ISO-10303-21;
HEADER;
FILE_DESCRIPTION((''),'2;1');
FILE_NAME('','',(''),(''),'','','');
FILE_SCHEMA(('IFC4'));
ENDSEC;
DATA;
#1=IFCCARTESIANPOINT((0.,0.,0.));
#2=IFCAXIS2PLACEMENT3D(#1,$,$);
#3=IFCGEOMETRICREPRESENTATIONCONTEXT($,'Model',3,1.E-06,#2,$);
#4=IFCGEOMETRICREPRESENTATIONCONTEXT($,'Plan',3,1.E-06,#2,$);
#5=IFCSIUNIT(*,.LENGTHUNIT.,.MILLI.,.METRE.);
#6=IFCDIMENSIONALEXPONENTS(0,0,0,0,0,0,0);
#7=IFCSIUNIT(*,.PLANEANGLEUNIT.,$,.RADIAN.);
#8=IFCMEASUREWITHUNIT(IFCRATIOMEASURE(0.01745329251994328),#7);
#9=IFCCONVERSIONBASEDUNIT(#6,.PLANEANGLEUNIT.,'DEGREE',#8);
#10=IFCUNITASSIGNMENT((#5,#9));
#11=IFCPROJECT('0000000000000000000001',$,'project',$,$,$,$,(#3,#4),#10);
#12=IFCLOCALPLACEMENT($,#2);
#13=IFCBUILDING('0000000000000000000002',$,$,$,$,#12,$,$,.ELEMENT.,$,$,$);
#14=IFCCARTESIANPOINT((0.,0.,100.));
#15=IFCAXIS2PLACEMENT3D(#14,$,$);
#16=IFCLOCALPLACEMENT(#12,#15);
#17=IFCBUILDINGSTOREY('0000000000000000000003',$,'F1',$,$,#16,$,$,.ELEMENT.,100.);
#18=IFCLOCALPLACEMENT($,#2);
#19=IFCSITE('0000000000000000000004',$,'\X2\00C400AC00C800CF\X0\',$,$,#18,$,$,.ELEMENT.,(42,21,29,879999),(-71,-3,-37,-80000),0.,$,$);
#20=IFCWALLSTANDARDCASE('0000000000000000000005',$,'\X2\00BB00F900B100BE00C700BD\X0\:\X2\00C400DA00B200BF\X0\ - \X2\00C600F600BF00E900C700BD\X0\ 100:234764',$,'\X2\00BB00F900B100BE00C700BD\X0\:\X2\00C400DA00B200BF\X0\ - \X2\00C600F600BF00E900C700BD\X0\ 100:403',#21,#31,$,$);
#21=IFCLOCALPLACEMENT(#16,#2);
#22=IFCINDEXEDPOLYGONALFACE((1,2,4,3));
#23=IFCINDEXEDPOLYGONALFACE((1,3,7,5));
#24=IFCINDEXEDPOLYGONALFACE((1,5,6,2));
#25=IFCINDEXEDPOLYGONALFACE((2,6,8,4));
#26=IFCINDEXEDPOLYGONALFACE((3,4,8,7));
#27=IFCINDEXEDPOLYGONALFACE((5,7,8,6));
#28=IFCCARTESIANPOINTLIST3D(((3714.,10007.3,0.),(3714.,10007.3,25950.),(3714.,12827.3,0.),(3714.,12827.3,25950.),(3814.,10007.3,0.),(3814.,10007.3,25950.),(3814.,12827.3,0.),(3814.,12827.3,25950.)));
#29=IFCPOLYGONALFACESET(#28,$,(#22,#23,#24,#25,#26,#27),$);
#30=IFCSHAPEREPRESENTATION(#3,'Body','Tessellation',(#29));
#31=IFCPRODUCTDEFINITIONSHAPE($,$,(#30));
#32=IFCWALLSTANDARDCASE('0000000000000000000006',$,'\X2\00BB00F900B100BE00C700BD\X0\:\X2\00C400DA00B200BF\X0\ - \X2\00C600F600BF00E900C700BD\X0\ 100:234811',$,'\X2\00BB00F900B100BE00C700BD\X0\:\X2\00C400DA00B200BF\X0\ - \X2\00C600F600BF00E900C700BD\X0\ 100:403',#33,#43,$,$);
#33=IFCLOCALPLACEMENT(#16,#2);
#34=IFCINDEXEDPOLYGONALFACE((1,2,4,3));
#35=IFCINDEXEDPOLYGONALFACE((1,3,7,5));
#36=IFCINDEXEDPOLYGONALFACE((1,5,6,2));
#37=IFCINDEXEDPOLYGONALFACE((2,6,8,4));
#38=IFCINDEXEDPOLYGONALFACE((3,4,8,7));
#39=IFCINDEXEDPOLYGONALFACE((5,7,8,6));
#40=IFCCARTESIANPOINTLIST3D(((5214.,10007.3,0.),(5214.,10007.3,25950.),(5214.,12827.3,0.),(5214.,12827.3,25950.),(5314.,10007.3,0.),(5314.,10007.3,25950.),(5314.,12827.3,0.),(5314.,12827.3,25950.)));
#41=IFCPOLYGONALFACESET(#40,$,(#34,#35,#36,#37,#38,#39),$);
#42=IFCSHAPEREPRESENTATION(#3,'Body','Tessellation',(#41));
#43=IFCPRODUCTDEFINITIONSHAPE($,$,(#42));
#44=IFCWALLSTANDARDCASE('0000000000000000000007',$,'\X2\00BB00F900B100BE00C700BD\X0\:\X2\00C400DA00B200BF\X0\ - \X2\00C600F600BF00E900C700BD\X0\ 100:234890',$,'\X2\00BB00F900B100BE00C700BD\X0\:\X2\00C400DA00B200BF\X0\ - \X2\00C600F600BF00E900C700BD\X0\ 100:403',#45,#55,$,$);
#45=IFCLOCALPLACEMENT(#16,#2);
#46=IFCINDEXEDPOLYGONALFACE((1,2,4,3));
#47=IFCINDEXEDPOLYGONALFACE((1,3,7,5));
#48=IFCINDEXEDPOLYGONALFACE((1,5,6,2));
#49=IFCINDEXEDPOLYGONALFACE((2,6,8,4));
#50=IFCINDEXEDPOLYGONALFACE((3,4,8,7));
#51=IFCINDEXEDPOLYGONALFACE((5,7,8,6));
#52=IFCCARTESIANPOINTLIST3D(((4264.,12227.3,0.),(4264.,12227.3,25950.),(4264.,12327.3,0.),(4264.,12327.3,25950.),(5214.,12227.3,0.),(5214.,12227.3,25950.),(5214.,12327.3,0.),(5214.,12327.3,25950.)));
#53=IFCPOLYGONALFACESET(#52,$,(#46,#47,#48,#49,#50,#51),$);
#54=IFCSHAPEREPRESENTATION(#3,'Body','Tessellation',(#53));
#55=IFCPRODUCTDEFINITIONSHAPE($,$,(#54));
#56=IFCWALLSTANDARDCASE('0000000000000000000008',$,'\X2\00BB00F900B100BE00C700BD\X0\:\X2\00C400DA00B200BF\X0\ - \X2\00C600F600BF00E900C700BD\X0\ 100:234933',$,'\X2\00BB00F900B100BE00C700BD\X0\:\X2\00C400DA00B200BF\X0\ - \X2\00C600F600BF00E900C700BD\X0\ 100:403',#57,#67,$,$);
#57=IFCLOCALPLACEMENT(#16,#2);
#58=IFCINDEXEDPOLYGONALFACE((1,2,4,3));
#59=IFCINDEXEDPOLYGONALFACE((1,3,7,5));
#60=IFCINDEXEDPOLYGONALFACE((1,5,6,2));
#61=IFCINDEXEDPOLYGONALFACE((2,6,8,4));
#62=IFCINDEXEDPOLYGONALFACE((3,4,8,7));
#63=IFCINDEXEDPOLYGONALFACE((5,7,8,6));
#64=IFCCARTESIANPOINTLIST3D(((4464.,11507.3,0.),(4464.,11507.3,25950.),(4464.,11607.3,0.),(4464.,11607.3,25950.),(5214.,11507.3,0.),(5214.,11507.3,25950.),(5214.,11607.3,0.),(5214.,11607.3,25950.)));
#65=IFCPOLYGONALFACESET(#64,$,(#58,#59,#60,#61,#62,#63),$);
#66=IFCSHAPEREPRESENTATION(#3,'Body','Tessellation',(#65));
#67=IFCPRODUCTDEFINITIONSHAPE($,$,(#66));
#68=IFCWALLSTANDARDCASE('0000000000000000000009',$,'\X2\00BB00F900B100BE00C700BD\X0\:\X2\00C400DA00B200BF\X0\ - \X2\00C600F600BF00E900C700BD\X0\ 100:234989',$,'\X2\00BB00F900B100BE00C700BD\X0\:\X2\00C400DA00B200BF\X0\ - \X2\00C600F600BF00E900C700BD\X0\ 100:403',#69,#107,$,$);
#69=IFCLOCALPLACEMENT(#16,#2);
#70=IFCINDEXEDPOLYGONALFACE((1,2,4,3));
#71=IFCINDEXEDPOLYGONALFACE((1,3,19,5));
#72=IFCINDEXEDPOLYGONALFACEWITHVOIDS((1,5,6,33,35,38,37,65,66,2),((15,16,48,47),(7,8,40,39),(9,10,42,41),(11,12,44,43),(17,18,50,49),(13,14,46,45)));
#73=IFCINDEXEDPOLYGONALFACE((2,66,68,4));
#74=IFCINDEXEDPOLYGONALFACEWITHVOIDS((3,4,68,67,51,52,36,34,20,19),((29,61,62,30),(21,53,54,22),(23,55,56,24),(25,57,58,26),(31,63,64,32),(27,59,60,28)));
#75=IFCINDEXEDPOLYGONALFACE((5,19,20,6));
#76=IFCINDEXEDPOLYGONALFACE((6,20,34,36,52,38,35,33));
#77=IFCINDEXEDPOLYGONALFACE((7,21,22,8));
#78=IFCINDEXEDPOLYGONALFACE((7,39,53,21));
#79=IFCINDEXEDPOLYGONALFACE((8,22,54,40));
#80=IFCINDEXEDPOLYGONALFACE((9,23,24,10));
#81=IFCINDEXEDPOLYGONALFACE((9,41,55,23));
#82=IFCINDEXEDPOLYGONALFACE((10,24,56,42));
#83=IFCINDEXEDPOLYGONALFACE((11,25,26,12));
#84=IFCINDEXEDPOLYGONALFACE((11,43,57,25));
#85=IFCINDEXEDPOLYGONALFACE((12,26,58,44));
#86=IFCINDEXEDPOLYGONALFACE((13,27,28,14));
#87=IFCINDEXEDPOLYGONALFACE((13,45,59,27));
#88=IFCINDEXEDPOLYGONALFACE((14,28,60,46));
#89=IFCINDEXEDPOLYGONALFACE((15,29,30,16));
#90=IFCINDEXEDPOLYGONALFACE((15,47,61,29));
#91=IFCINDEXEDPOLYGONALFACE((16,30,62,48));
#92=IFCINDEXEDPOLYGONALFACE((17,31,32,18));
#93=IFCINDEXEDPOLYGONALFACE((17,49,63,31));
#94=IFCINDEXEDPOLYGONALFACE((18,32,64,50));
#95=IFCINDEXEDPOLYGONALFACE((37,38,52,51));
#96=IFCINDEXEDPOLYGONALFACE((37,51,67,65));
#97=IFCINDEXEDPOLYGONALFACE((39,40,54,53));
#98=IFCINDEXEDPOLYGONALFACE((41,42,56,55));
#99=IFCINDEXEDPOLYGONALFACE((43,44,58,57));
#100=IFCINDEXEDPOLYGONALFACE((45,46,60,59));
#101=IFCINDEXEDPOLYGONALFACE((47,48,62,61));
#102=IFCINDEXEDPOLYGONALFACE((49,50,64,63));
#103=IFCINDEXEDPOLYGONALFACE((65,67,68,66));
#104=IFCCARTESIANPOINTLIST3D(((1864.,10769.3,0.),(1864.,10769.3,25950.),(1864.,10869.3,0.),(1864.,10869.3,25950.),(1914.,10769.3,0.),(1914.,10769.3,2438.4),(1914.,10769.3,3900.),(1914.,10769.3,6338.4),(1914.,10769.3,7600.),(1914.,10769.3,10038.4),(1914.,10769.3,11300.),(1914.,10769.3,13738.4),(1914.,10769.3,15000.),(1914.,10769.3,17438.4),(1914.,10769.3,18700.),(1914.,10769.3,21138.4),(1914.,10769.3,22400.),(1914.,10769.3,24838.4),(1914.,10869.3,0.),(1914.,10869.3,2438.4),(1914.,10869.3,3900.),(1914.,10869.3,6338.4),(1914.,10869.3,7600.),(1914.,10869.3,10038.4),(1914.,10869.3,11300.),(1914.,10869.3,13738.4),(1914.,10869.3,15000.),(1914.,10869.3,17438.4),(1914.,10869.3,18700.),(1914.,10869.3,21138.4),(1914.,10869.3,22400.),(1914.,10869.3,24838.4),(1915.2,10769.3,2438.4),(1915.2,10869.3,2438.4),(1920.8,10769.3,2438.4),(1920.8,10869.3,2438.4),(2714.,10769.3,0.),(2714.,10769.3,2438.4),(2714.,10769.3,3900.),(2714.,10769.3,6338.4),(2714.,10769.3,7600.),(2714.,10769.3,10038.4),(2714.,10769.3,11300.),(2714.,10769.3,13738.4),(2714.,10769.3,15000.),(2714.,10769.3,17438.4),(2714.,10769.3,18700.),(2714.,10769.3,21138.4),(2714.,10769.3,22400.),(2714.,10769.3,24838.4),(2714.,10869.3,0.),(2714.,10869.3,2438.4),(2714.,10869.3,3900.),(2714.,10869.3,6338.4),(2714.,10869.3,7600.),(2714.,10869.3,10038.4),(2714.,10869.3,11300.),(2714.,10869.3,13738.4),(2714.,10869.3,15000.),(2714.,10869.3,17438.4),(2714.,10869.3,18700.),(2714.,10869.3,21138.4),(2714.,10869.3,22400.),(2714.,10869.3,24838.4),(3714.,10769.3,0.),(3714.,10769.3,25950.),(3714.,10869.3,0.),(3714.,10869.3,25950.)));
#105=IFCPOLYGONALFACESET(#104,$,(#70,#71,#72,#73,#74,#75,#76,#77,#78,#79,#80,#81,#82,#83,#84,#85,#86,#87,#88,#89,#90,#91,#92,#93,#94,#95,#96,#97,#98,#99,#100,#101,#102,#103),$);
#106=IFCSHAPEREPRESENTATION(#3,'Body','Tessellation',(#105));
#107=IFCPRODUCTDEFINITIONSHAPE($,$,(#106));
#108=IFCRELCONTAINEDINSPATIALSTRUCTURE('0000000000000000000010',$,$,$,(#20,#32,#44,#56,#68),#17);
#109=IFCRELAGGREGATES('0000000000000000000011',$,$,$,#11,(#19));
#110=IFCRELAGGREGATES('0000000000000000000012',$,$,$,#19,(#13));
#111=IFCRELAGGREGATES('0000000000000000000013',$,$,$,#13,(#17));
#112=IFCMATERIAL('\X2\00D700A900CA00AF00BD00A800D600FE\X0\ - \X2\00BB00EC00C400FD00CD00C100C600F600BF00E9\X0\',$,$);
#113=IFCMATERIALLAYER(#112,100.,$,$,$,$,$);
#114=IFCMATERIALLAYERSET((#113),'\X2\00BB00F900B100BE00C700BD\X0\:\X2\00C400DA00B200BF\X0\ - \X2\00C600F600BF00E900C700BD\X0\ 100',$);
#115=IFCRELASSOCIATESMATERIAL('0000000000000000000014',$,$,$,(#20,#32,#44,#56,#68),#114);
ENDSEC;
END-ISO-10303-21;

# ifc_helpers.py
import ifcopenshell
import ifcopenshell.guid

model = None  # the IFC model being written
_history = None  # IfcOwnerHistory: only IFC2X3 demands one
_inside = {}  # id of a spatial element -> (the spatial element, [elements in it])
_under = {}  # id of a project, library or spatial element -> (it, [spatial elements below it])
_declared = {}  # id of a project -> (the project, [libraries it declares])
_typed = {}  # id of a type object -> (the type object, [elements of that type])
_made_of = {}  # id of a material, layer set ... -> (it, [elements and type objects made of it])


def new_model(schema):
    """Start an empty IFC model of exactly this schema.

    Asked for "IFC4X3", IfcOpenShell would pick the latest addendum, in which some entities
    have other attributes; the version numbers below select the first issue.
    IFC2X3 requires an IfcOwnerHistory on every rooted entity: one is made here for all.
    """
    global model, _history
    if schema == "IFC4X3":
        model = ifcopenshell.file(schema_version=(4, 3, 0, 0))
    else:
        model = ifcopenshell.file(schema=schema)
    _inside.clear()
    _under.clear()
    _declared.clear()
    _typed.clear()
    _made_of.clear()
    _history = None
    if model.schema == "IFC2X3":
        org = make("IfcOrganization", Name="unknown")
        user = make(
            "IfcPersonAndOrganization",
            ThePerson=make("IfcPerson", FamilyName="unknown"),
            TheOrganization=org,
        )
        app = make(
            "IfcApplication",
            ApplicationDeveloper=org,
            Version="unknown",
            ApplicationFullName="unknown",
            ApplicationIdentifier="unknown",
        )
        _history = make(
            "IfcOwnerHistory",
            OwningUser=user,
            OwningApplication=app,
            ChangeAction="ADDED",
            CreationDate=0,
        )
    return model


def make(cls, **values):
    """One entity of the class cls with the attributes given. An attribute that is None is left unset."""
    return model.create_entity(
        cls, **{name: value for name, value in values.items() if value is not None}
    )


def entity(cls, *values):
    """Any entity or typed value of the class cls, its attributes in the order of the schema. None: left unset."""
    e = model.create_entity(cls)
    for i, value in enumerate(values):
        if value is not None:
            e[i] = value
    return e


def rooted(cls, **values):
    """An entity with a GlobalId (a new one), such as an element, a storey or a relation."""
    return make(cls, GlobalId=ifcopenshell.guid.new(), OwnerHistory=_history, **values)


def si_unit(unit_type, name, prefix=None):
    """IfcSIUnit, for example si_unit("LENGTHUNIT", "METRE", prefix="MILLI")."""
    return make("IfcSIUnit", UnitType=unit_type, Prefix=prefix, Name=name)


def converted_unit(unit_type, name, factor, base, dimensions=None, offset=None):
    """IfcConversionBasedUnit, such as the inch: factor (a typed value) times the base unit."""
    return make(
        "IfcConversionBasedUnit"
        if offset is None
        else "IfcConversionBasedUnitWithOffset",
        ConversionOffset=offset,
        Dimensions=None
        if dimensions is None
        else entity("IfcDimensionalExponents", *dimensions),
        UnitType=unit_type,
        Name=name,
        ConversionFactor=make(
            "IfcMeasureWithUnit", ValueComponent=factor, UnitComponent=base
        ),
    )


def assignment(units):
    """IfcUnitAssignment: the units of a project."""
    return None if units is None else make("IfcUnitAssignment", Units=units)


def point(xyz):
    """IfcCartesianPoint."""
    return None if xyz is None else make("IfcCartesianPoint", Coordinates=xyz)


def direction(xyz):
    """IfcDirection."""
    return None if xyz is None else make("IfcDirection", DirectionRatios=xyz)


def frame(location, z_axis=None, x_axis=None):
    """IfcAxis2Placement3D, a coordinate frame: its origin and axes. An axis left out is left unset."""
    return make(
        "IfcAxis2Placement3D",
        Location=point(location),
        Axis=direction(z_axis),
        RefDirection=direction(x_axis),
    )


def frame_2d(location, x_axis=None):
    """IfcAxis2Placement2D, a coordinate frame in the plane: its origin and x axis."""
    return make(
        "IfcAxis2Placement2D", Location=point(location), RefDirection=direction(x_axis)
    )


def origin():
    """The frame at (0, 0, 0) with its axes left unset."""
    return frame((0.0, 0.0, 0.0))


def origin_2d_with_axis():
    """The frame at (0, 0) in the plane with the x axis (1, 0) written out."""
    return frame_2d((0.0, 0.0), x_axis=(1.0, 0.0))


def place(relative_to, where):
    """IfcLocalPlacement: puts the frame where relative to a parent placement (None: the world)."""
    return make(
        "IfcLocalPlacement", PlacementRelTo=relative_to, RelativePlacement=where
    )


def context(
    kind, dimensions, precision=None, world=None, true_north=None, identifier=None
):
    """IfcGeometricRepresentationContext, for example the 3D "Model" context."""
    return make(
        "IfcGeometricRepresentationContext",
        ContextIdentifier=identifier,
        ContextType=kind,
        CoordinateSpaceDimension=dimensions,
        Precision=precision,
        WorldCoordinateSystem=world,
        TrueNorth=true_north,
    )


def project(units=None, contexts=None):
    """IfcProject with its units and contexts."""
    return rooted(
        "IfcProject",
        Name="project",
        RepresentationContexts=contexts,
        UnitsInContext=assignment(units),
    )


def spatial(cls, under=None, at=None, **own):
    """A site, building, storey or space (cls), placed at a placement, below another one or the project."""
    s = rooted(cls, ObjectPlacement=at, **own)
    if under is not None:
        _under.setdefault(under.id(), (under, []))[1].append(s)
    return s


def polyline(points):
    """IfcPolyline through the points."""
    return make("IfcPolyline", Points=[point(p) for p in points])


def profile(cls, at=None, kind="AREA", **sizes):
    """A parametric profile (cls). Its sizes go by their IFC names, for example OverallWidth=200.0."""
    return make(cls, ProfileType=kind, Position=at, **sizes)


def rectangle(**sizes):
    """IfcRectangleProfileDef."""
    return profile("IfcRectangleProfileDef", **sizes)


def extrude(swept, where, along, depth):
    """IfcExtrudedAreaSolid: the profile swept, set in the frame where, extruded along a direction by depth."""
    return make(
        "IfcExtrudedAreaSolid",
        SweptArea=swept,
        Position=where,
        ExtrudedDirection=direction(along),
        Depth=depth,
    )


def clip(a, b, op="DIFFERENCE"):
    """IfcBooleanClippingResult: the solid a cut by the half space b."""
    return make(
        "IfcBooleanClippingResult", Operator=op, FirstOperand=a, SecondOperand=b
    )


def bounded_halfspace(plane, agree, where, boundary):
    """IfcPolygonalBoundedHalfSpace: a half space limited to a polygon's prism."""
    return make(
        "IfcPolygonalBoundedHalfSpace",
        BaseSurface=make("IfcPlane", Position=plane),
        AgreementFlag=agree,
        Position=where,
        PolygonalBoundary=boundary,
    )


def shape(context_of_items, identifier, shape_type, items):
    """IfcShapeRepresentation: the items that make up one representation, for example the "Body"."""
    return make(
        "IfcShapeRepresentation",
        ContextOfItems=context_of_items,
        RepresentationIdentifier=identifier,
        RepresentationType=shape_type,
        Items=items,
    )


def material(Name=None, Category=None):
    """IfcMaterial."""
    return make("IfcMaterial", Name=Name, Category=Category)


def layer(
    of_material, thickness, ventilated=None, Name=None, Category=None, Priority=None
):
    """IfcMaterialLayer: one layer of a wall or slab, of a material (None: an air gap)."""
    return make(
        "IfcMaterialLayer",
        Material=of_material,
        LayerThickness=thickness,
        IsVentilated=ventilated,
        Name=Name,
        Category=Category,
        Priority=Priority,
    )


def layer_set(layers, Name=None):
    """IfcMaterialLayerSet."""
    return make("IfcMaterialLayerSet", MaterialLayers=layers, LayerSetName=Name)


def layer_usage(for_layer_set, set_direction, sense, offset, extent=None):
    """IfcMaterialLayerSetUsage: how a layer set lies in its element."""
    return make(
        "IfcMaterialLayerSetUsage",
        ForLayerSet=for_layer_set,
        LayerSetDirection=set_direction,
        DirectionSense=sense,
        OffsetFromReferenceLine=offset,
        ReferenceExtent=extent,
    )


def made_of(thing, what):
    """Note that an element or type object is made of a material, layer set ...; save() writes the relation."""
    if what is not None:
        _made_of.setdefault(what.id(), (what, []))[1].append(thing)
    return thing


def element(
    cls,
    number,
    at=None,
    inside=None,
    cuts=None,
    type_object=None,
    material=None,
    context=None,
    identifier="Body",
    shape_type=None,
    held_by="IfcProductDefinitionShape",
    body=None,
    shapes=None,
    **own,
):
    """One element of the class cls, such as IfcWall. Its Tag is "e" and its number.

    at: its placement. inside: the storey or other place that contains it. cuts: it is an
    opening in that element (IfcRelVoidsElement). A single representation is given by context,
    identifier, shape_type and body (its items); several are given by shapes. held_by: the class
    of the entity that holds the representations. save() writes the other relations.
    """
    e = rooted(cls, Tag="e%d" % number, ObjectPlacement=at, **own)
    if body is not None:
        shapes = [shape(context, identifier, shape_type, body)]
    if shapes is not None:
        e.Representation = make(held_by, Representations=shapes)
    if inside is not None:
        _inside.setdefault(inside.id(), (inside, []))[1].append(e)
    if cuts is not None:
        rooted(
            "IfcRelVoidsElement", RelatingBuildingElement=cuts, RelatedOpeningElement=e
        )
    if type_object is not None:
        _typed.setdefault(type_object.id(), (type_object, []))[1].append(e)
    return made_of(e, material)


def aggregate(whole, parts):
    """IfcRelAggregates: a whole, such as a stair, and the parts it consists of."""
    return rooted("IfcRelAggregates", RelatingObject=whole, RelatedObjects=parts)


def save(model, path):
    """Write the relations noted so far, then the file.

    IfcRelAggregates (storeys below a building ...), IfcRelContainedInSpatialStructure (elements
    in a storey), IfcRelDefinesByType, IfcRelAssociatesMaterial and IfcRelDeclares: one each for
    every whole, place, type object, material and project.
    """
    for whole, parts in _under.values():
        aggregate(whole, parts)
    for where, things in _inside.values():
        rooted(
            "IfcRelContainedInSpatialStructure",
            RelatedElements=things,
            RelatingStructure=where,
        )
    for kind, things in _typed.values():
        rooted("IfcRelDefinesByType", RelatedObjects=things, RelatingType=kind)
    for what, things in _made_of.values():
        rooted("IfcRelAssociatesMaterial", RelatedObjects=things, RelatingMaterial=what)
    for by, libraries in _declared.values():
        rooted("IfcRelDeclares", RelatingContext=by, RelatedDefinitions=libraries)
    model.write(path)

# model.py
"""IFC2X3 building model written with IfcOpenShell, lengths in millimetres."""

from ifc_helpers import new_model, entity, si_unit, converted_unit, frame, frame_2d, origin, origin_2d_with_axis, place, context, project, spatial, polyline, rectangle, extrude, clip, bounded_halfspace, material, layer, layer_set, layer_usage, element, save


model = new_model("IFC2X3")

# Units and contexts
model_context = context("Model", 3, precision=1e-06, world=origin())
plan_context = context("Plan", 3, precision=1e-06, world=origin())
ifc_project = project(units=[si_unit("LENGTHUNIT", "METRE", prefix="MILLI"), converted_unit("PLANEANGLEUNIT", "DEGREE", entity("IfcRatioMeasure", 0.01745329251994328), si_unit("PLANEANGLEUNIT", "RADIAN"), dimensions=[0, 0, 0, 0, 0, 0, 0])], contexts=[model_context, plan_context])

# Site, building, storey
site_placement = place(None, origin())
site = spatial("IfcSite", under=ifc_project, at=site_placement, Name="Ä¬ÈÏ", CompositionType="ELEMENT", RefLatitude=(42, 21, 29, 879999), RefLongitude=(-71, -3, -37, -80000), RefElevation=0.0)
building_placement = place(None, origin())
building = spatial("IfcBuilding", under=site, at=building_placement, CompositionType="ELEMENT")
storey_placement = place(building_placement, frame((0.0, 0.0, 100.0)))
storey = spatial("IfcBuildingStorey", under=building, at=storey_placement, Name="F1", CompositionType="ELEMENT", Elevation=100.0)

# Walls
ifc_material = material(Name="×©Ê¯½¨Öþ - »ìÄýÍÁÆö¿é")
ifc_layer = layer(ifc_material, 100.0)
ifc_layer_set = layer_set([ifc_layer], Name="»ù±¾Ç½:ÄÚ²¿ - Æö¿éÇ½ 100")
ifc_layer_usage_1 = layer_usage(ifc_layer_set, "AXIS2", "NEGATIVE", 50.0)
wall_1_placement = place(storey_placement, frame((3764.0, 12827.3, 0.0), z_axis=(0.0, 0.0, 1.0), x_axis=(0.0, -1.0, 0.0)))
element("IfcWallStandardCase", 1, at=wall_1_placement, inside=storey, material=ifc_layer_usage_1, Name="»ù±¾Ç½:ÄÚ²¿ - Æö¿éÇ½ 100:234764", ObjectType="»ù±¾Ç½:ÄÚ²¿ - Æö¿éÇ½ 100:403", context=model_context, shape_type="Clipping", body=[
    clip(extrude(rectangle(XDim=2820.0, YDim=100.0, at=frame_2d((1410.0, 0.0), x_axis=(-1.0, 0.0))), origin(), (0.0, 0.0, 1.0), 25950.0), bounded_halfspace(frame((0.0, -50.0, 25950.0), z_axis=(0.0, 0.0, -1.0), x_axis=(0.0, 1.0, 0.0)), True, frame((0.0, -50.0, 25950.0)), polyline([(0.0, 0.0), (1958.0, 0.0), (2058.0, 0.0), (2820.0, 0.0), (2820.0, 100.0), (0.0, 100.0), (0.0, 0.0)]))),
])
ifc_layer_usage_2 = layer_usage(ifc_layer_set, "AXIS2", "NEGATIVE", 50.0)
wall_2_placement = place(storey_placement, frame((5264.0, 10007.3, 0.0), z_axis=(0.0, 0.0, 1.0), x_axis=(0.0, 1.0, 0.0)))
element("IfcWallStandardCase", 2, at=wall_2_placement, inside=storey, material=ifc_layer_usage_2, Name="»ù±¾Ç½:ÄÚ²¿ - Æö¿éÇ½ 100:234811", ObjectType="»ù±¾Ç½:ÄÚ²¿ - Æö¿éÇ½ 100:403", context=model_context, shape_type="Clipping", body=[
    clip(extrude(rectangle(XDim=2820.0, YDim=100.0, at=frame_2d((1410.0, 0.0), x_axis=(-1.0, 0.0))), origin(), (0.0, 0.0, 1.0), 25950.0), bounded_halfspace(frame((0.0, -50.0, 25950.0), z_axis=(0.0, 0.0, -1.0), x_axis=(0.0, -1.0, 0.0)), True, frame((0.0, -50.0, 25950.0)), polyline([(0.0, 0.0), (2820.0, 0.0), (2820.0, 100.0), (2320.0, 100.0), (2220.0, 100.0), (1600.0, 100.0), (1500.0, 100.0), (0.0, 100.0), (0.0, 0.0)]))),
])
ifc_layer_usage_3 = layer_usage(ifc_layer_set, "AXIS2", "NEGATIVE", 50.0)
wall_3_placement = place(storey_placement, frame((4264.0, 12277.3, 0.0)))
element("IfcWallStandardCase", 3, at=wall_3_placement, inside=storey, material=ifc_layer_usage_3, Name="»ù±¾Ç½:ÄÚ²¿ - Æö¿éÇ½ 100:234890", ObjectType="»ù±¾Ç½:ÄÚ²¿ - Æö¿éÇ½ 100:403", context=model_context, shape_type="Clipping", body=[
    clip(extrude(rectangle(XDim=950.0, YDim=100.0, at=frame_2d((475.0, 0.0), x_axis=(-1.0, 0.0))), origin(), (0.0, 0.0, 1.0), 25950.0), bounded_halfspace(frame((0.0, -50.0, 25950.0), z_axis=(0.0, 0.0, -1.0), x_axis=(1.0, 0.0, 0.0)), True, frame((0.0, -50.0, 25950.0)), polyline([(0.0, 0.0), (950.0, 0.0), (950.0, 100.0), (0.0, 100.0), (0.0, 0.0)]))),
])
ifc_layer_usage_4 = layer_usage(ifc_layer_set, "AXIS2", "NEGATIVE", 50.0)
wall_4_placement = place(storey_placement, frame((5214.0, 11557.3, 0.0), z_axis=(0.0, 0.0, 1.0), x_axis=(-1.0, 0.0, 0.0)))
element("IfcWallStandardCase", 4, at=wall_4_placement, inside=storey, material=ifc_layer_usage_4, Name="»ù±¾Ç½:ÄÚ²¿ - Æö¿éÇ½ 100:234933", ObjectType="»ù±¾Ç½:ÄÚ²¿ - Æö¿éÇ½ 100:403", context=model_context, shape_type="Clipping", body=[
    clip(extrude(rectangle(XDim=750.0, YDim=100.0, at=frame_2d((375.0, 0.0), x_axis=(-1.0, 0.0))), origin(), (0.0, 0.0, 1.0), 25950.0), bounded_halfspace(frame((0.0, -50.0, 25950.0), z_axis=(0.0, 0.0, -1.0), x_axis=(-1.0, 0.0, 0.0)), True, frame((0.0, -50.0, 25950.0)), polyline([(0.0, 0.0), (750.0, 0.0), (750.0, 100.0), (0.0, 100.0), (0.0, 0.0)]))),
])

# Wall, openings
ifc_layer_usage_5 = layer_usage(ifc_layer_set, "AXIS2", "NEGATIVE", 50.0)
wall_5_placement = place(storey_placement, frame((1864.0, 10819.3, 0.0)))
wall_5 = element("IfcWallStandardCase", 5, at=wall_5_placement, inside=storey, material=ifc_layer_usage_5, Name="»ù±¾Ç½:ÄÚ²¿ - Æö¿éÇ½ 100:234989", ObjectType="»ù±¾Ç½:ÄÚ²¿ - Æö¿éÇ½ 100:403", context=model_context, shape_type="Clipping", body=[
    clip(extrude(rectangle(XDim=1850.0, YDim=100.0, at=frame_2d((925.0, 0.0), x_axis=(-1.0, 0.0))), origin(), (0.0, 0.0, 1.0), 25950.0), bounded_halfspace(frame((0.0, -50.0, 25950.0), z_axis=(0.0, 0.0, -1.0), x_axis=(1.0, 0.0, 0.0)), True, frame((0.0, -50.0, 25950.0)), polyline([(0.0, 0.0), (1850.0, 0.0), (1850.0, 100.0), (0.0, 100.0), (0.0, 0.0)]))),
])
opening_1_placement = place(wall_5_placement, origin())
element("IfcOpeningElement", 6, at=opening_1_placement, cuts=wall_5, ObjectType="Opening", context=model_context, shape_type="SweptSolid", body=[
    extrude(rectangle(XDim=2438.4, YDim=5.6, at=origin_2d_with_axis()), frame((54.1, -50.0, 1219.2), z_axis=(0.0, 1.0, 0.0), x_axis=(0.0, 0.0, -1.0)), (0.0, 0.0, 1.0), 100.0),
])
opening_2_placement = place(wall_5_placement, origin())
element("IfcOpeningElement", 7, at=opening_2_placement, cuts=wall_5, ObjectType="Opening", context=model_context, shape_type="SweptSolid", body=[
    extrude(rectangle(XDim=2438.4, YDim=800.0, at=origin_2d_with_axis()), frame((450.0, -50.0, 1219.2), z_axis=(0.0, 1.0, 0.0), x_axis=(0.0, 0.0, -1.0)), (0.0, 0.0, 1.0), 100.0),
])
opening_3_placement = place(wall_5_placement, origin())
element("IfcOpeningElement", 8, at=opening_3_placement, cuts=wall_5, ObjectType="Opening", context=model_context, shape_type="SweptSolid", body=[
    extrude(rectangle(XDim=2438.4, YDim=800.0, at=origin_2d_with_axis()), frame((450.0, -50.0, 5119.2), z_axis=(0.0, 1.0, 0.0), x_axis=(0.0, 0.0, -1.0)), (0.0, 0.0, 1.0), 100.0),
])
opening_4_placement = place(wall_5_placement, origin())
element("IfcOpeningElement", 9, at=opening_4_placement, cuts=wall_5, ObjectType="Opening", context=model_context, shape_type="SweptSolid", body=[
    extrude(rectangle(XDim=2438.4, YDim=800.0, at=origin_2d_with_axis()), frame((450.0, -50.0, 8819.2), z_axis=(0.0, 1.0, 0.0), x_axis=(0.0, 0.0, -1.0)), (0.0, 0.0, 1.0), 100.0),
])
opening_5_placement = place(wall_5_placement, origin())
element("IfcOpeningElement", 10, at=opening_5_placement, cuts=wall_5, ObjectType="Opening", context=model_context, shape_type="SweptSolid", body=[
    extrude(rectangle(XDim=2438.4, YDim=800.0, at=origin_2d_with_axis()), frame((450.0, -50.0, 12519.2), z_axis=(0.0, 1.0, 0.0), x_axis=(0.0, 0.0, -1.0)), (0.0, 0.0, 1.0), 100.0),
])
opening_6_placement = place(wall_5_placement, origin())
element("IfcOpeningElement", 11, at=opening_6_placement, cuts=wall_5, ObjectType="Opening", context=model_context, shape_type="SweptSolid", body=[
    extrude(rectangle(XDim=2438.4, YDim=800.0, at=origin_2d_with_axis()), frame((450.0, -50.0, 16219.2), z_axis=(0.0, 1.0, 0.0), x_axis=(0.0, 0.0, -1.0)), (0.0, 0.0, 1.0), 100.0),
])
opening_7_placement = place(wall_5_placement, origin())
element("IfcOpeningElement", 12, at=opening_7_placement, cuts=wall_5, ObjectType="Opening", context=model_context, shape_type="SweptSolid", body=[
    extrude(rectangle(XDim=2438.4, YDim=800.0, at=origin_2d_with_axis()), frame((450.0, -50.0, 19919.2), z_axis=(0.0, 1.0, 0.0), x_axis=(0.0, 0.0, -1.0)), (0.0, 0.0, 1.0), 100.0),
])
opening_8_placement = place(wall_5_placement, origin())
element("IfcOpeningElement", 13, at=opening_8_placement, cuts=wall_5, ObjectType="Opening", context=model_context, shape_type="SweptSolid", body=[
    extrude(rectangle(XDim=2438.4, YDim=800.0, at=origin_2d_with_axis()), frame((450.0, -50.0, 23619.2), z_axis=(0.0, 1.0, 0.0), x_axis=(0.0, 0.0, -1.0)), (0.0, 0.0, 1.0), 100.0),
])

save(model, "model.ifc")
